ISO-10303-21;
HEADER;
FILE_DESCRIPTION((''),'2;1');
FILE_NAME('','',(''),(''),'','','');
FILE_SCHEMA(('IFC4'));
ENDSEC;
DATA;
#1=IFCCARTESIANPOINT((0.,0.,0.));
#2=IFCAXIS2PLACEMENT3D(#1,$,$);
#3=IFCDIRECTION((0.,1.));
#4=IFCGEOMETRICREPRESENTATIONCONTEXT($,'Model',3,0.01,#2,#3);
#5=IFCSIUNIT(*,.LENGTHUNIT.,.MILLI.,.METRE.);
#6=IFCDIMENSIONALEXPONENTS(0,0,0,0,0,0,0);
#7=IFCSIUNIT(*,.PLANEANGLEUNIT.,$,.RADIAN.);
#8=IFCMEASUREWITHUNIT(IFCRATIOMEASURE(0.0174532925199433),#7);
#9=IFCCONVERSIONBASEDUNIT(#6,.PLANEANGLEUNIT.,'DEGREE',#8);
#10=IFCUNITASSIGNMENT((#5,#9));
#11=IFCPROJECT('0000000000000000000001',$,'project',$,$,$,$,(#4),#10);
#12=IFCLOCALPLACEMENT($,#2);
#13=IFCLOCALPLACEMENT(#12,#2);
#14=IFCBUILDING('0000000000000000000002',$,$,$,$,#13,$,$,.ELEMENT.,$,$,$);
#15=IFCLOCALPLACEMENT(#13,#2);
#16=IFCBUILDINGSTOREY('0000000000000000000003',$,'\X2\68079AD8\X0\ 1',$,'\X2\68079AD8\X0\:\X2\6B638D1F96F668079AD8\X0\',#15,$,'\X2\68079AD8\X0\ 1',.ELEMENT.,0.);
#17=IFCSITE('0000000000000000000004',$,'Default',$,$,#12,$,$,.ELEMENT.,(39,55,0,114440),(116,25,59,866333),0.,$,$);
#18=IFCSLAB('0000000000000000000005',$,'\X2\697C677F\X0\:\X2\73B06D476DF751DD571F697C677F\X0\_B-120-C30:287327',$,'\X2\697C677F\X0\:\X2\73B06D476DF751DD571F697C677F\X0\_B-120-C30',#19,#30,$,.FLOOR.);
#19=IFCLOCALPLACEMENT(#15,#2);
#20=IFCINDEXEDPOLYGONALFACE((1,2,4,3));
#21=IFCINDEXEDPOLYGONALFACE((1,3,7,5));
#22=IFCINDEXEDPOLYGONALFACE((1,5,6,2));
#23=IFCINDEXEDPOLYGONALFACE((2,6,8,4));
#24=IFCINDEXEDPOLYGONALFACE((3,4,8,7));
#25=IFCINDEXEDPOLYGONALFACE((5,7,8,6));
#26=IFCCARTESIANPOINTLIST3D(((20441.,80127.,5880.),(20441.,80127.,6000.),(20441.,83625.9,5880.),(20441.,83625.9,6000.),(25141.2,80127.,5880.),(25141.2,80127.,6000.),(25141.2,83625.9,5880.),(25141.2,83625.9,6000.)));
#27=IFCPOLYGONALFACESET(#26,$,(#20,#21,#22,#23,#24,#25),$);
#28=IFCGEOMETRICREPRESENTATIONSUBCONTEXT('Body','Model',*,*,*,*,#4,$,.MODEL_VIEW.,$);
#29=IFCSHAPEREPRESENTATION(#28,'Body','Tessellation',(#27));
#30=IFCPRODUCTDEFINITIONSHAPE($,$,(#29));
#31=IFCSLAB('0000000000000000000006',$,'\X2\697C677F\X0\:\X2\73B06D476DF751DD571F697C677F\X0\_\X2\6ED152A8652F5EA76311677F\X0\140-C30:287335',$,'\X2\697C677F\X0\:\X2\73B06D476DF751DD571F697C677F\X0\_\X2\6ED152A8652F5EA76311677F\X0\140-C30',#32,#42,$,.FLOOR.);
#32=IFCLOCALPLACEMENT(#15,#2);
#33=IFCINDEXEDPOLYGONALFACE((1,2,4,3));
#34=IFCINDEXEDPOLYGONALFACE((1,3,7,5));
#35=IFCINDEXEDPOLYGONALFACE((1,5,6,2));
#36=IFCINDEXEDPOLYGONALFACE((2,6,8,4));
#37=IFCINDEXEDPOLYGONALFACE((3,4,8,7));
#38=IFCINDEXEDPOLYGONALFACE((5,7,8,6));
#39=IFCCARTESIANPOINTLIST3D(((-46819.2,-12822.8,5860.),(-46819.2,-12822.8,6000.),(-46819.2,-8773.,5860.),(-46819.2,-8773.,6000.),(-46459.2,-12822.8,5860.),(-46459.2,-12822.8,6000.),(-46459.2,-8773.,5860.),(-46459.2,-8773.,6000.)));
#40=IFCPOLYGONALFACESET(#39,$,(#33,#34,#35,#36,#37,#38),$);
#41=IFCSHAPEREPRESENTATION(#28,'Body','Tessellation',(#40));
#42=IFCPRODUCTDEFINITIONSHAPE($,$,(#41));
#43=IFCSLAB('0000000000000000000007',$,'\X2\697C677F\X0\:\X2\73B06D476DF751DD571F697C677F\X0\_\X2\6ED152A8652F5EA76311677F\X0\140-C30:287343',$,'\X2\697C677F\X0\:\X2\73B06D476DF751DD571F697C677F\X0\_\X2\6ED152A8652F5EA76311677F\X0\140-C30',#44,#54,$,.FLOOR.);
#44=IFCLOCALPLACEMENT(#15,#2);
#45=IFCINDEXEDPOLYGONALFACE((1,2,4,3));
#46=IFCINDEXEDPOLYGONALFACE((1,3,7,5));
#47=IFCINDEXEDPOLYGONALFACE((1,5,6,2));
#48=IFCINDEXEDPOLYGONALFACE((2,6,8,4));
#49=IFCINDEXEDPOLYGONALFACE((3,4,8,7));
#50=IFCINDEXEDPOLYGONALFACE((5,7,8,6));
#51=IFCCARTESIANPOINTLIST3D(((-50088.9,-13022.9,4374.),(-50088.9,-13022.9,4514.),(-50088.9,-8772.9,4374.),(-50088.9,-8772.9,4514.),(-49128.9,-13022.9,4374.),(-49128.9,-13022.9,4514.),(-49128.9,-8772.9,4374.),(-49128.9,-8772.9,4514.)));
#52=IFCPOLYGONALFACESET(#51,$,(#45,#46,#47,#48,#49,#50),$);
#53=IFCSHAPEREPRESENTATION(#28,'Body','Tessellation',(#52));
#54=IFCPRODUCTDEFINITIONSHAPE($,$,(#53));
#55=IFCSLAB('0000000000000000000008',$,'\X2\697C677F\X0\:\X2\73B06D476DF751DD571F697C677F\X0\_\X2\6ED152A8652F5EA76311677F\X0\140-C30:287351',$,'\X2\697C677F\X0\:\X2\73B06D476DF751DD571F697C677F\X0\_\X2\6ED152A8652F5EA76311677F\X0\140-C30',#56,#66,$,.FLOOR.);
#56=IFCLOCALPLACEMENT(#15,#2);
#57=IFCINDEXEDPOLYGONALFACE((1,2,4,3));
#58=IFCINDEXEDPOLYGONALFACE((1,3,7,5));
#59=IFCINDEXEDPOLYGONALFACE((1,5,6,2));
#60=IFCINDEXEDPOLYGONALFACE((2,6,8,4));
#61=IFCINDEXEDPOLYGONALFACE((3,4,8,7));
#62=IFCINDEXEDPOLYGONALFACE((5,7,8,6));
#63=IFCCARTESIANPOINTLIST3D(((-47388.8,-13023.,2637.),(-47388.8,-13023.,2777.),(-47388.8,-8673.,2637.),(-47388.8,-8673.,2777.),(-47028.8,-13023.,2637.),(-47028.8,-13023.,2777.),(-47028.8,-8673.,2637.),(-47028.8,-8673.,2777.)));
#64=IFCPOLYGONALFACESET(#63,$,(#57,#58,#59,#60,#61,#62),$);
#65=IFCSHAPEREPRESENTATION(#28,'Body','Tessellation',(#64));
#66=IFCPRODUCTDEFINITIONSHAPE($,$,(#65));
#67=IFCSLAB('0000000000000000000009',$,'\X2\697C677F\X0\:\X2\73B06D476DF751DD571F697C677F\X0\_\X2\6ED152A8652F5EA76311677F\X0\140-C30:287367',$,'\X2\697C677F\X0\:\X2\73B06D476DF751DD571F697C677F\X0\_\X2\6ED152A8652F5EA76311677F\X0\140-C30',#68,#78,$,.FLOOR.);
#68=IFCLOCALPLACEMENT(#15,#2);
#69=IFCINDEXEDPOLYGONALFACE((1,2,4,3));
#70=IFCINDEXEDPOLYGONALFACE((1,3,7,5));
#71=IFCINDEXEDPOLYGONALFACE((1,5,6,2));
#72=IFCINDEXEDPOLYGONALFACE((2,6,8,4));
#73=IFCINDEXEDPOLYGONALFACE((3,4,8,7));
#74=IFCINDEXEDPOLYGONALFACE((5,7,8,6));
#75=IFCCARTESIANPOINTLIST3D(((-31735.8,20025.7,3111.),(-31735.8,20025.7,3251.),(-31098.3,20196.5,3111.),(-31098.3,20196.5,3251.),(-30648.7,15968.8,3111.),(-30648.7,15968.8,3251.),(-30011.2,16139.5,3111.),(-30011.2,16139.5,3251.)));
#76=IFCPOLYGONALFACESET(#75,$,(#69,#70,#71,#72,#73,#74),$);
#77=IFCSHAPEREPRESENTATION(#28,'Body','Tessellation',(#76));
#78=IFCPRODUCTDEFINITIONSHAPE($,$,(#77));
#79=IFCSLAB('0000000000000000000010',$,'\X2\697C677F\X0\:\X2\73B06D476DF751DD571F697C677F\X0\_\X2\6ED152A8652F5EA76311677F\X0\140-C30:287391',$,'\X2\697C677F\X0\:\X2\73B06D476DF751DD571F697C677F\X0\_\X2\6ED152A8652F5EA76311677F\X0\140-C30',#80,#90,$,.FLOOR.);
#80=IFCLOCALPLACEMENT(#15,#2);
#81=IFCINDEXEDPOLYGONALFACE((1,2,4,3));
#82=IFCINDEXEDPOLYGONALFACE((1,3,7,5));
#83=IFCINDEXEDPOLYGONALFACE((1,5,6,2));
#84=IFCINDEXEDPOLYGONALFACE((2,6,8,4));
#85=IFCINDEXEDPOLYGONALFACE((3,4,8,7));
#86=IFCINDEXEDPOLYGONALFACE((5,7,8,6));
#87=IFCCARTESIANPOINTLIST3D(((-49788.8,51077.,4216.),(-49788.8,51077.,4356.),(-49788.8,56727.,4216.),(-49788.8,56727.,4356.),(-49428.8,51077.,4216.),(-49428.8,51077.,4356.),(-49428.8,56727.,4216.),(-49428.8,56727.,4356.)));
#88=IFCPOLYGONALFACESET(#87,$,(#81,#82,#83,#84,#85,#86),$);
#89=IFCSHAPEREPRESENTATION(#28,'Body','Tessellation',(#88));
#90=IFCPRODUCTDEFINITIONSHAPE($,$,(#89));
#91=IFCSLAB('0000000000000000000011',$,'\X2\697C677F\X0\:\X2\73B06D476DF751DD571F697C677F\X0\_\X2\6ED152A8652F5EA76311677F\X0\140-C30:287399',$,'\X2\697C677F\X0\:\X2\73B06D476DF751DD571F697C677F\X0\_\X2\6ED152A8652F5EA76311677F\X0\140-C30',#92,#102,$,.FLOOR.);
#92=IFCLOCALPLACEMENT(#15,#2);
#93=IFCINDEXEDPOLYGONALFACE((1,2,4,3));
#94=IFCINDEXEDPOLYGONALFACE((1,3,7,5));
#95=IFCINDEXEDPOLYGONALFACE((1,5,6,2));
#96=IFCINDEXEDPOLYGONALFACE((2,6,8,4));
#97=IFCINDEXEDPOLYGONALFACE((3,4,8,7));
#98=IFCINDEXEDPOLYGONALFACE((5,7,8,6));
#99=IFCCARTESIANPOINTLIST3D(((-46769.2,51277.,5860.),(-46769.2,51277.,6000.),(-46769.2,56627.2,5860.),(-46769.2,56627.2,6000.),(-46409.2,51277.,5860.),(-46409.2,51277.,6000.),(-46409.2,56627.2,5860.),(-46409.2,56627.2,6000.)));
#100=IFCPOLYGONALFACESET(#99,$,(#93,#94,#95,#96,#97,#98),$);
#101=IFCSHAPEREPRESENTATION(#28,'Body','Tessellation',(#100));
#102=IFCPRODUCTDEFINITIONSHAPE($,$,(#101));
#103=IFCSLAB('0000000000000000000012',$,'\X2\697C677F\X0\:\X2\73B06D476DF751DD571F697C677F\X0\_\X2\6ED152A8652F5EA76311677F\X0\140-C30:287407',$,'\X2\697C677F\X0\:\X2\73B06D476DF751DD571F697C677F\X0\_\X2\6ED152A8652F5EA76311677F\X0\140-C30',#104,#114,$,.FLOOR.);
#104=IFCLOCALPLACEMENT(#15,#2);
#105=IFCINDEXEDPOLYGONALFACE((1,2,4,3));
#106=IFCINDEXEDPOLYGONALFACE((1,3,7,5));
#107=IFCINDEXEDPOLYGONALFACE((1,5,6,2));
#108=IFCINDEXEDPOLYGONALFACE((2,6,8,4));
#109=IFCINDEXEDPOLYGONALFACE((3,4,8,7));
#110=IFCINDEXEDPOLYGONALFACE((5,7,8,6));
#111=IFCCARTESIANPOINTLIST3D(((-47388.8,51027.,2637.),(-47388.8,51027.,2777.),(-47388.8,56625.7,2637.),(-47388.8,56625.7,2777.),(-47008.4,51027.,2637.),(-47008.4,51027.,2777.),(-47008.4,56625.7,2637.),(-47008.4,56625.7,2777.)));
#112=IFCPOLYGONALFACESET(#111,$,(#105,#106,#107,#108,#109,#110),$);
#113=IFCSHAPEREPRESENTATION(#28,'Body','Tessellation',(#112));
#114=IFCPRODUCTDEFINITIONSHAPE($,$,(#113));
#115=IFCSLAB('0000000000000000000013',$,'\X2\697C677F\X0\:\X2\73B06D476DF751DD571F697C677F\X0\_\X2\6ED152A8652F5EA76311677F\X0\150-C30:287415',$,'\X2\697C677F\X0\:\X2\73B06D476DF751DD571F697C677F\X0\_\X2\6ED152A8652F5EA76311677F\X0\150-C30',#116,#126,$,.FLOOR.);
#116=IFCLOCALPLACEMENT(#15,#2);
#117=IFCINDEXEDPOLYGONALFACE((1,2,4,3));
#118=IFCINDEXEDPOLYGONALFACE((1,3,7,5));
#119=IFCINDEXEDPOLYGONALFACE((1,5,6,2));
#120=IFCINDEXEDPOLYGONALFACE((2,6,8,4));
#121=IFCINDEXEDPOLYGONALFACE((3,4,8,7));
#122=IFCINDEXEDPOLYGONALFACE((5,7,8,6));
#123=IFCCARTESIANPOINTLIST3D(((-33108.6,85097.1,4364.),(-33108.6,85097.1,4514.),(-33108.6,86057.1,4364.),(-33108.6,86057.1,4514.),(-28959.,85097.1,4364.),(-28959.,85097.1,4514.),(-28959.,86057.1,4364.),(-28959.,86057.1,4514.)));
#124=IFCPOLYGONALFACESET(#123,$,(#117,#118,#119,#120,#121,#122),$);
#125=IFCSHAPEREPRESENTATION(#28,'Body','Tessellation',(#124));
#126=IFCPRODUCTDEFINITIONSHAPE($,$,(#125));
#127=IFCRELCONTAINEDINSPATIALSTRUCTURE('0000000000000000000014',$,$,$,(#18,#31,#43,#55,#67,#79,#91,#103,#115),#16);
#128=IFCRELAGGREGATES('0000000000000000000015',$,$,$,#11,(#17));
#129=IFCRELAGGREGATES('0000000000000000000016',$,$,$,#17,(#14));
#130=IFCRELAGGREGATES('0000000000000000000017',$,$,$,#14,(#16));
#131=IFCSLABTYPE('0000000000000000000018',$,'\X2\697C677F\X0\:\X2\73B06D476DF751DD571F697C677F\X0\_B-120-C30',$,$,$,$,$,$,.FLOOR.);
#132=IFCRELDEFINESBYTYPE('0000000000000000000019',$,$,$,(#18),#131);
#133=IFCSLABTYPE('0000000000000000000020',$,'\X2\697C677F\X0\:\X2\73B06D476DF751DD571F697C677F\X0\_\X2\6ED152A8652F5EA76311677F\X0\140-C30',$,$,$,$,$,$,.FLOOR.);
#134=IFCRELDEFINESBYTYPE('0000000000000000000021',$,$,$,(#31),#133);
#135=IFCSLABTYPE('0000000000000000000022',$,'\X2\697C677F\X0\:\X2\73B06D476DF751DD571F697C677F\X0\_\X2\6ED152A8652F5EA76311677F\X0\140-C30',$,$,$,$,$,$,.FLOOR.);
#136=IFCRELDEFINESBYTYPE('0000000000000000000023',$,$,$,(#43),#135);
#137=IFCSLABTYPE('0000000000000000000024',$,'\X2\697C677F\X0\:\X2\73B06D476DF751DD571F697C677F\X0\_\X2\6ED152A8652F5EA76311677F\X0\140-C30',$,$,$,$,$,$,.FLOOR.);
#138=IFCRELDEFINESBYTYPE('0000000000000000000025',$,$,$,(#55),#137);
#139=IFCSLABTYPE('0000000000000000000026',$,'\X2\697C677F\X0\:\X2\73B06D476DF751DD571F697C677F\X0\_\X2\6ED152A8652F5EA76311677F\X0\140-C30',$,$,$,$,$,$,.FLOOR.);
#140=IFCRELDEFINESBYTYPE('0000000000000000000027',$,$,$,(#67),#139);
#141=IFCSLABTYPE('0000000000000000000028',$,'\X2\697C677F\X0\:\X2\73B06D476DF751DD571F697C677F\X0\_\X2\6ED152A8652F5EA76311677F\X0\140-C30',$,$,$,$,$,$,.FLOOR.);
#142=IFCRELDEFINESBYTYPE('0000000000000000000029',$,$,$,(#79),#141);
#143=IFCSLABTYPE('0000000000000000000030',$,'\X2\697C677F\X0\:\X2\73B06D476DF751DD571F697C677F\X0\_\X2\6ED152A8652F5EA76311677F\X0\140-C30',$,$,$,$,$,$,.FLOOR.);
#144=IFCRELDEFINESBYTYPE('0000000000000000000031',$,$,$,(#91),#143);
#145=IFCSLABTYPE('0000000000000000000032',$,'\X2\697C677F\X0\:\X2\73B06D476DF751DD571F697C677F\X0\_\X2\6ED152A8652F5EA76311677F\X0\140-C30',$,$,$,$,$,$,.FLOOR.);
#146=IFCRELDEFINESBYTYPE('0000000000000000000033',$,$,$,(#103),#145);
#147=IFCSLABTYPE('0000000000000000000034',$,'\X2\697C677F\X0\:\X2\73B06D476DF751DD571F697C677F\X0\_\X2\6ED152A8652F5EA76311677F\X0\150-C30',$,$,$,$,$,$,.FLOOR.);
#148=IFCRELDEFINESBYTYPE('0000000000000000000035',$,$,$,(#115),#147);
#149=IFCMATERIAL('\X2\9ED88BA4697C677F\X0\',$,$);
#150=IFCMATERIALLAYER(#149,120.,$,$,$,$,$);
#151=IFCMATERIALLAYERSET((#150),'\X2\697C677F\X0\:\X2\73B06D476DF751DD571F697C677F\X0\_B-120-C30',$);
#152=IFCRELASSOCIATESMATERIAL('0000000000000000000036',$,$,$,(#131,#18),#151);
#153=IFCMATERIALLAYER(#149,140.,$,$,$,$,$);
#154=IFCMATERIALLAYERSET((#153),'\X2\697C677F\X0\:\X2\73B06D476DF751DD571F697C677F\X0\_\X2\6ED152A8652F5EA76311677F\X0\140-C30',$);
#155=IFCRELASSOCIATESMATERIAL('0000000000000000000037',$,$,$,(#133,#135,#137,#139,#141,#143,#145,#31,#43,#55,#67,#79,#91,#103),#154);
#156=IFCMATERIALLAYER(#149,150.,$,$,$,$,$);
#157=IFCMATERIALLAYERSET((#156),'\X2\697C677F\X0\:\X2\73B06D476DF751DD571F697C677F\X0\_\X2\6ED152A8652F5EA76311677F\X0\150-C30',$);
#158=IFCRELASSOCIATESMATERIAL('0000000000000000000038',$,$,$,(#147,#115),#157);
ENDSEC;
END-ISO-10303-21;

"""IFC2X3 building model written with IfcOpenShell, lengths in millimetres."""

from ifc_helpers import new_model, entity, si_unit, converted_unit, direction, frame, frame_2d, origin, place, context, subcontext, project, spatial, polyline, rectangle, outline, extrude, material, layer, layer_set, layer_usage, type_object, element, save


model = new_model("IFC2X3")

# Units and contexts
model_context = context("Model", 3, precision=0.01, world=origin(), true_north=direction((0.0, 1.0)))
body_context = subcontext(model_context, "Body", "Model", "MODEL_VIEW")
ifc_project = project(units=[si_unit("LENGTHUNIT", "METRE", prefix="MILLI"), converted_unit("PLANEANGLEUNIT", "DEGREE", entity("IfcRatioMeasure", 0.0174532925199433), si_unit("PLANEANGLEUNIT", "RADIAN"), dimensions=[0, 0, 0, 0, 0, 0, 0])], contexts=[model_context])

# Site, building, storey
site_placement = place(None, origin())
site = spatial("IfcSite", under=ifc_project, at=site_placement, Name="Default", CompositionType="ELEMENT", RefLatitude=(39, 55, 0, 114440), RefLongitude=(116, 25, 59, 866333), RefElevation=0.0)
building_placement = place(site_placement, origin())
building = spatial("IfcBuilding", under=site, at=building_placement, CompositionType="ELEMENT")
storey_placement = place(building_placement, origin())
storey = spatial("IfcBuildingStorey", under=building, at=storey_placement, Name="标高 1", ObjectType="标高:正负零标高", LongName="标高 1", CompositionType="ELEMENT", Elevation=0.0)

# Slabs
ifc_material = material(Name="默认楼板")
ifc_layer_1 = layer(ifc_material, 120.0)
ifc_layer_set_1 = layer_set([ifc_layer_1], Name="楼板:现浇混凝土楼板_B-120-C30")
ifc_layer_usage_1 = layer_usage(ifc_layer_set_1, "AXIS3", "POSITIVE", 0.0)
slab_type_1 = type_object("IfcSlabType", Name="楼板:现浇混凝土楼板_B-120-C30", PredefinedType="FLOOR", material=ifc_layer_set_1)
slab_1_placement = place(building_placement, origin())
element("IfcSlab", 1, at=slab_1_placement, inside=storey, type_object=slab_type_1, material=ifc_layer_usage_1, Name="楼板:现浇混凝土楼板_B-120-C30:287327", ObjectType="楼板:现浇混凝土楼板_B-120-C30", PredefinedType="FLOOR", context=body_context, shape_type="SweptSolid", body=[
    extrude(outline(polyline([(-1749.5, -2350.1), (1749.5, -2350.1), (1749.5, 2350.1), (-1749.5, 2350.1), (-1749.5, -2350.1)])), frame((22791.1, 81876.5, 6000.0), z_axis=(0.0, 0.0, -1.0), x_axis=(0.0, 1.0, 0.0)), (0.0, 0.0, 1.0), 120.0),
])
ifc_layer_2 = layer(ifc_material, 140.0)
ifc_layer_set_2 = layer_set([ifc_layer_2], Name="楼板:现浇混凝土楼板_滑动支座挑板140-C30")
ifc_layer_usage_2 = layer_usage(ifc_layer_set_2, "AXIS3", "POSITIVE", 0.0)
slab_type_2 = type_object("IfcSlabType", Name="楼板:现浇混凝土楼板_滑动支座挑板140-C30", PredefinedType="FLOOR", material=ifc_layer_set_2)
slab_2_placement = place(building_placement, origin())
element("IfcSlab", 2, at=slab_2_placement, inside=storey, type_object=slab_type_2, material=ifc_layer_usage_2, Name="楼板:现浇混凝土楼板_滑动支座挑板140-C30:287335", ObjectType="楼板:现浇混凝土楼板_滑动支座挑板140-C30", PredefinedType="FLOOR", context=body_context, shape_type="SweptSolid", body=[
    extrude(rectangle(XDim=4049.8, YDim=360.0, at=frame_2d((0.0, 0.0), x_axis=(1.0, 0.0))), frame((-46639.2, -10797.9, 6000.0), z_axis=(0.0, 0.0, -1.0), x_axis=(0.0, 1.0, 0.0)), (0.0, 0.0, 1.0), 140.0),
])
ifc_layer_usage_3 = layer_usage(ifc_layer_set_2, "AXIS3", "POSITIVE", 0.0)
slab_type_3 = type_object("IfcSlabType", Name="楼板:现浇混凝土楼板_滑动支座挑板140-C30", PredefinedType="FLOOR", material=ifc_layer_set_2)
slab_3_placement = place(building_placement, origin())
element("IfcSlab", 3, at=slab_3_placement, inside=storey, type_object=slab_type_3, material=ifc_layer_usage_3, Name="楼板:现浇混凝土楼板_滑动支座挑板140-C30:287343", ObjectType="楼板:现浇混凝土楼板_滑动支座挑板140-C30", PredefinedType="FLOOR", context=body_context, shape_type="SweptSolid", body=[
    extrude(rectangle(XDim=4250.0, YDim=960.0, at=frame_2d((0.0, 0.0), x_axis=(1.0, 0.0))), frame((-49608.9, -10897.9, 4514.0), z_axis=(0.0, 0.0, -1.0), x_axis=(0.0, 1.0, 0.0)), (0.0, 0.0, 1.0), 140.0),
])
ifc_layer_usage_4 = layer_usage(ifc_layer_set_2, "AXIS3", "POSITIVE", 0.0)
slab_type_4 = type_object("IfcSlabType", Name="楼板:现浇混凝土楼板_滑动支座挑板140-C30", PredefinedType="FLOOR", material=ifc_layer_set_2)
slab_4_placement = place(building_placement, origin())
element("IfcSlab", 4, at=slab_4_placement, inside=storey, type_object=slab_type_4, material=ifc_layer_usage_4, Name="楼板:现浇混凝土楼板_滑动支座挑板140-C30:287351", ObjectType="楼板:现浇混凝土楼板_滑动支座挑板140-C30", PredefinedType="FLOOR", context=body_context, shape_type="SweptSolid", body=[
    extrude(rectangle(XDim=4350.0, YDim=360.0, at=frame_2d((0.0, 0.0), x_axis=(1.0, 0.0))), frame((-47208.8, -10848.0, 2777.0), z_axis=(0.0, 0.0, -1.0), x_axis=(0.0, 1.0, 0.0)), (0.0, 0.0, 1.0), 140.0),
])
ifc_layer_usage_5 = layer_usage(ifc_layer_set_2, "AXIS3", "POSITIVE", 0.0)
slab_type_5 = type_object("IfcSlabType", Name="楼板:现浇混凝土楼板_滑动支座挑板140-C30", PredefinedType="FLOOR", material=ifc_layer_set_2)
slab_5_placement = place(building_placement, origin())
element("IfcSlab", 5, at=slab_5_placement, inside=storey, type_object=slab_type_5, material=ifc_layer_usage_5, Name="楼板:现浇混凝土楼板_滑动支座挑板140-C30:287367", ObjectType="楼板:现浇混凝土楼板_滑动支座挑板140-C30", PredefinedType="FLOOR", context=body_context, shape_type="SweptSolid", body=[
    extrude(outline(polyline([(-2100.0, -330.0), (2100.1, -330.0), (2100.0, 330.0), (-2100.0, 330.0), (-2100.0, -330.0)])), frame((-30873.5, 18082.6, 3251.0), z_axis=(0.0, 0.0, -1.0), x_axis=(0.258819, -0.965926, 0.0)), (0.0, 0.0, 1.0), 140.0),
])
ifc_layer_usage_6 = layer_usage(ifc_layer_set_2, "AXIS3", "POSITIVE", 0.0)
slab_type_6 = type_object("IfcSlabType", Name="楼板:现浇混凝土楼板_滑动支座挑板140-C30", PredefinedType="FLOOR", material=ifc_layer_set_2)
slab_6_placement = place(building_placement, origin())
element("IfcSlab", 6, at=slab_6_placement, inside=storey, type_object=slab_type_6, material=ifc_layer_usage_6, Name="楼板:现浇混凝土楼板_滑动支座挑板140-C30:287391", ObjectType="楼板:现浇混凝土楼板_滑动支座挑板140-C30", PredefinedType="FLOOR", context=body_context, shape_type="SweptSolid", body=[
    extrude(rectangle(XDim=5650.0, YDim=360.0, at=frame_2d((0.0, 0.0), x_axis=(1.0, 0.0))), frame((-49608.8, 53902.0, 4356.0), z_axis=(0.0, 0.0, -1.0), x_axis=(0.0, 1.0, 0.0)), (0.0, 0.0, 1.0), 140.0),
])
ifc_layer_usage_7 = layer_usage(ifc_layer_set_2, "AXIS3", "POSITIVE", 0.0)
slab_type_7 = type_object("IfcSlabType", Name="楼板:现浇混凝土楼板_滑动支座挑板140-C30", PredefinedType="FLOOR", material=ifc_layer_set_2)
slab_7_placement = place(building_placement, origin())
element("IfcSlab", 7, at=slab_7_placement, inside=storey, type_object=slab_type_7, material=ifc_layer_usage_7, Name="楼板:现浇混凝土楼板_滑动支座挑板140-C30:287399", ObjectType="楼板:现浇混凝土楼板_滑动支座挑板140-C30", PredefinedType="FLOOR", context=body_context, shape_type="SweptSolid", body=[
    extrude(rectangle(XDim=5350.2, YDim=360.0, at=frame_2d((0.0, 0.0), x_axis=(1.0, 0.0))), frame((-46589.2, 53952.1, 6000.0), z_axis=(0.0, 0.0, -1.0), x_axis=(0.0, 1.0, 0.0)), (0.0, 0.0, 1.0), 140.0),
])
ifc_layer_usage_8 = layer_usage(ifc_layer_set_2, "AXIS3", "POSITIVE", 0.0)
slab_type_8 = type_object("IfcSlabType", Name="楼板:现浇混凝土楼板_滑动支座挑板140-C30", PredefinedType="FLOOR", material=ifc_layer_set_2)
slab_8_placement = place(building_placement, origin())
element("IfcSlab", 8, at=slab_8_placement, inside=storey, type_object=slab_type_8, material=ifc_layer_usage_8, Name="楼板:现浇混凝土楼板_滑动支座挑板140-C30:287407", ObjectType="楼板:现浇混凝土楼板_滑动支座挑板140-C30", PredefinedType="FLOOR", context=body_context, shape_type="SweptSolid", body=[
    extrude(rectangle(XDim=5598.7, YDim=380.5, at=frame_2d((0.0, 0.0), x_axis=(1.0, 0.0))), frame((-47198.6, 53826.3, 2777.0), z_axis=(0.0, 0.0, -1.0), x_axis=(0.0, 1.0, 0.0)), (0.0, 0.0, 1.0), 140.0),
])
ifc_layer_3 = layer(ifc_material, 150.0)
ifc_layer_set_3 = layer_set([ifc_layer_3], Name="楼板:现浇混凝土楼板_滑动支座挑板150-C30")
ifc_layer_usage_9 = layer_usage(ifc_layer_set_3, "AXIS3", "POSITIVE", 0.0)
slab_type_9 = type_object("IfcSlabType", Name="楼板:现浇混凝土楼板_滑动支座挑板150-C30", PredefinedType="FLOOR", material=ifc_layer_set_3)
slab_9_placement = place(building_placement, origin())
element("IfcSlab", 9, at=slab_9_placement, inside=storey, type_object=slab_type_9, material=ifc_layer_usage_9, Name="楼板:现浇混凝土楼板_滑动支座挑板150-C30:287415", ObjectType="楼板:现浇混凝土楼板_滑动支座挑板150-C30", PredefinedType="FLOOR", context=body_context, shape_type="SweptSolid", body=[
    extrude(rectangle(XDim=960.0, YDim=4149.6, at=frame_2d((0.0, 0.0), x_axis=(1.0, 0.0))), frame((-31033.8, 85577.1, 4514.0), z_axis=(0.0, 0.0, -1.0), x_axis=(0.0, 1.0, 0.0)), (0.0, 0.0, 1.0), 150.0),
])

save(model, "model.ifc")
